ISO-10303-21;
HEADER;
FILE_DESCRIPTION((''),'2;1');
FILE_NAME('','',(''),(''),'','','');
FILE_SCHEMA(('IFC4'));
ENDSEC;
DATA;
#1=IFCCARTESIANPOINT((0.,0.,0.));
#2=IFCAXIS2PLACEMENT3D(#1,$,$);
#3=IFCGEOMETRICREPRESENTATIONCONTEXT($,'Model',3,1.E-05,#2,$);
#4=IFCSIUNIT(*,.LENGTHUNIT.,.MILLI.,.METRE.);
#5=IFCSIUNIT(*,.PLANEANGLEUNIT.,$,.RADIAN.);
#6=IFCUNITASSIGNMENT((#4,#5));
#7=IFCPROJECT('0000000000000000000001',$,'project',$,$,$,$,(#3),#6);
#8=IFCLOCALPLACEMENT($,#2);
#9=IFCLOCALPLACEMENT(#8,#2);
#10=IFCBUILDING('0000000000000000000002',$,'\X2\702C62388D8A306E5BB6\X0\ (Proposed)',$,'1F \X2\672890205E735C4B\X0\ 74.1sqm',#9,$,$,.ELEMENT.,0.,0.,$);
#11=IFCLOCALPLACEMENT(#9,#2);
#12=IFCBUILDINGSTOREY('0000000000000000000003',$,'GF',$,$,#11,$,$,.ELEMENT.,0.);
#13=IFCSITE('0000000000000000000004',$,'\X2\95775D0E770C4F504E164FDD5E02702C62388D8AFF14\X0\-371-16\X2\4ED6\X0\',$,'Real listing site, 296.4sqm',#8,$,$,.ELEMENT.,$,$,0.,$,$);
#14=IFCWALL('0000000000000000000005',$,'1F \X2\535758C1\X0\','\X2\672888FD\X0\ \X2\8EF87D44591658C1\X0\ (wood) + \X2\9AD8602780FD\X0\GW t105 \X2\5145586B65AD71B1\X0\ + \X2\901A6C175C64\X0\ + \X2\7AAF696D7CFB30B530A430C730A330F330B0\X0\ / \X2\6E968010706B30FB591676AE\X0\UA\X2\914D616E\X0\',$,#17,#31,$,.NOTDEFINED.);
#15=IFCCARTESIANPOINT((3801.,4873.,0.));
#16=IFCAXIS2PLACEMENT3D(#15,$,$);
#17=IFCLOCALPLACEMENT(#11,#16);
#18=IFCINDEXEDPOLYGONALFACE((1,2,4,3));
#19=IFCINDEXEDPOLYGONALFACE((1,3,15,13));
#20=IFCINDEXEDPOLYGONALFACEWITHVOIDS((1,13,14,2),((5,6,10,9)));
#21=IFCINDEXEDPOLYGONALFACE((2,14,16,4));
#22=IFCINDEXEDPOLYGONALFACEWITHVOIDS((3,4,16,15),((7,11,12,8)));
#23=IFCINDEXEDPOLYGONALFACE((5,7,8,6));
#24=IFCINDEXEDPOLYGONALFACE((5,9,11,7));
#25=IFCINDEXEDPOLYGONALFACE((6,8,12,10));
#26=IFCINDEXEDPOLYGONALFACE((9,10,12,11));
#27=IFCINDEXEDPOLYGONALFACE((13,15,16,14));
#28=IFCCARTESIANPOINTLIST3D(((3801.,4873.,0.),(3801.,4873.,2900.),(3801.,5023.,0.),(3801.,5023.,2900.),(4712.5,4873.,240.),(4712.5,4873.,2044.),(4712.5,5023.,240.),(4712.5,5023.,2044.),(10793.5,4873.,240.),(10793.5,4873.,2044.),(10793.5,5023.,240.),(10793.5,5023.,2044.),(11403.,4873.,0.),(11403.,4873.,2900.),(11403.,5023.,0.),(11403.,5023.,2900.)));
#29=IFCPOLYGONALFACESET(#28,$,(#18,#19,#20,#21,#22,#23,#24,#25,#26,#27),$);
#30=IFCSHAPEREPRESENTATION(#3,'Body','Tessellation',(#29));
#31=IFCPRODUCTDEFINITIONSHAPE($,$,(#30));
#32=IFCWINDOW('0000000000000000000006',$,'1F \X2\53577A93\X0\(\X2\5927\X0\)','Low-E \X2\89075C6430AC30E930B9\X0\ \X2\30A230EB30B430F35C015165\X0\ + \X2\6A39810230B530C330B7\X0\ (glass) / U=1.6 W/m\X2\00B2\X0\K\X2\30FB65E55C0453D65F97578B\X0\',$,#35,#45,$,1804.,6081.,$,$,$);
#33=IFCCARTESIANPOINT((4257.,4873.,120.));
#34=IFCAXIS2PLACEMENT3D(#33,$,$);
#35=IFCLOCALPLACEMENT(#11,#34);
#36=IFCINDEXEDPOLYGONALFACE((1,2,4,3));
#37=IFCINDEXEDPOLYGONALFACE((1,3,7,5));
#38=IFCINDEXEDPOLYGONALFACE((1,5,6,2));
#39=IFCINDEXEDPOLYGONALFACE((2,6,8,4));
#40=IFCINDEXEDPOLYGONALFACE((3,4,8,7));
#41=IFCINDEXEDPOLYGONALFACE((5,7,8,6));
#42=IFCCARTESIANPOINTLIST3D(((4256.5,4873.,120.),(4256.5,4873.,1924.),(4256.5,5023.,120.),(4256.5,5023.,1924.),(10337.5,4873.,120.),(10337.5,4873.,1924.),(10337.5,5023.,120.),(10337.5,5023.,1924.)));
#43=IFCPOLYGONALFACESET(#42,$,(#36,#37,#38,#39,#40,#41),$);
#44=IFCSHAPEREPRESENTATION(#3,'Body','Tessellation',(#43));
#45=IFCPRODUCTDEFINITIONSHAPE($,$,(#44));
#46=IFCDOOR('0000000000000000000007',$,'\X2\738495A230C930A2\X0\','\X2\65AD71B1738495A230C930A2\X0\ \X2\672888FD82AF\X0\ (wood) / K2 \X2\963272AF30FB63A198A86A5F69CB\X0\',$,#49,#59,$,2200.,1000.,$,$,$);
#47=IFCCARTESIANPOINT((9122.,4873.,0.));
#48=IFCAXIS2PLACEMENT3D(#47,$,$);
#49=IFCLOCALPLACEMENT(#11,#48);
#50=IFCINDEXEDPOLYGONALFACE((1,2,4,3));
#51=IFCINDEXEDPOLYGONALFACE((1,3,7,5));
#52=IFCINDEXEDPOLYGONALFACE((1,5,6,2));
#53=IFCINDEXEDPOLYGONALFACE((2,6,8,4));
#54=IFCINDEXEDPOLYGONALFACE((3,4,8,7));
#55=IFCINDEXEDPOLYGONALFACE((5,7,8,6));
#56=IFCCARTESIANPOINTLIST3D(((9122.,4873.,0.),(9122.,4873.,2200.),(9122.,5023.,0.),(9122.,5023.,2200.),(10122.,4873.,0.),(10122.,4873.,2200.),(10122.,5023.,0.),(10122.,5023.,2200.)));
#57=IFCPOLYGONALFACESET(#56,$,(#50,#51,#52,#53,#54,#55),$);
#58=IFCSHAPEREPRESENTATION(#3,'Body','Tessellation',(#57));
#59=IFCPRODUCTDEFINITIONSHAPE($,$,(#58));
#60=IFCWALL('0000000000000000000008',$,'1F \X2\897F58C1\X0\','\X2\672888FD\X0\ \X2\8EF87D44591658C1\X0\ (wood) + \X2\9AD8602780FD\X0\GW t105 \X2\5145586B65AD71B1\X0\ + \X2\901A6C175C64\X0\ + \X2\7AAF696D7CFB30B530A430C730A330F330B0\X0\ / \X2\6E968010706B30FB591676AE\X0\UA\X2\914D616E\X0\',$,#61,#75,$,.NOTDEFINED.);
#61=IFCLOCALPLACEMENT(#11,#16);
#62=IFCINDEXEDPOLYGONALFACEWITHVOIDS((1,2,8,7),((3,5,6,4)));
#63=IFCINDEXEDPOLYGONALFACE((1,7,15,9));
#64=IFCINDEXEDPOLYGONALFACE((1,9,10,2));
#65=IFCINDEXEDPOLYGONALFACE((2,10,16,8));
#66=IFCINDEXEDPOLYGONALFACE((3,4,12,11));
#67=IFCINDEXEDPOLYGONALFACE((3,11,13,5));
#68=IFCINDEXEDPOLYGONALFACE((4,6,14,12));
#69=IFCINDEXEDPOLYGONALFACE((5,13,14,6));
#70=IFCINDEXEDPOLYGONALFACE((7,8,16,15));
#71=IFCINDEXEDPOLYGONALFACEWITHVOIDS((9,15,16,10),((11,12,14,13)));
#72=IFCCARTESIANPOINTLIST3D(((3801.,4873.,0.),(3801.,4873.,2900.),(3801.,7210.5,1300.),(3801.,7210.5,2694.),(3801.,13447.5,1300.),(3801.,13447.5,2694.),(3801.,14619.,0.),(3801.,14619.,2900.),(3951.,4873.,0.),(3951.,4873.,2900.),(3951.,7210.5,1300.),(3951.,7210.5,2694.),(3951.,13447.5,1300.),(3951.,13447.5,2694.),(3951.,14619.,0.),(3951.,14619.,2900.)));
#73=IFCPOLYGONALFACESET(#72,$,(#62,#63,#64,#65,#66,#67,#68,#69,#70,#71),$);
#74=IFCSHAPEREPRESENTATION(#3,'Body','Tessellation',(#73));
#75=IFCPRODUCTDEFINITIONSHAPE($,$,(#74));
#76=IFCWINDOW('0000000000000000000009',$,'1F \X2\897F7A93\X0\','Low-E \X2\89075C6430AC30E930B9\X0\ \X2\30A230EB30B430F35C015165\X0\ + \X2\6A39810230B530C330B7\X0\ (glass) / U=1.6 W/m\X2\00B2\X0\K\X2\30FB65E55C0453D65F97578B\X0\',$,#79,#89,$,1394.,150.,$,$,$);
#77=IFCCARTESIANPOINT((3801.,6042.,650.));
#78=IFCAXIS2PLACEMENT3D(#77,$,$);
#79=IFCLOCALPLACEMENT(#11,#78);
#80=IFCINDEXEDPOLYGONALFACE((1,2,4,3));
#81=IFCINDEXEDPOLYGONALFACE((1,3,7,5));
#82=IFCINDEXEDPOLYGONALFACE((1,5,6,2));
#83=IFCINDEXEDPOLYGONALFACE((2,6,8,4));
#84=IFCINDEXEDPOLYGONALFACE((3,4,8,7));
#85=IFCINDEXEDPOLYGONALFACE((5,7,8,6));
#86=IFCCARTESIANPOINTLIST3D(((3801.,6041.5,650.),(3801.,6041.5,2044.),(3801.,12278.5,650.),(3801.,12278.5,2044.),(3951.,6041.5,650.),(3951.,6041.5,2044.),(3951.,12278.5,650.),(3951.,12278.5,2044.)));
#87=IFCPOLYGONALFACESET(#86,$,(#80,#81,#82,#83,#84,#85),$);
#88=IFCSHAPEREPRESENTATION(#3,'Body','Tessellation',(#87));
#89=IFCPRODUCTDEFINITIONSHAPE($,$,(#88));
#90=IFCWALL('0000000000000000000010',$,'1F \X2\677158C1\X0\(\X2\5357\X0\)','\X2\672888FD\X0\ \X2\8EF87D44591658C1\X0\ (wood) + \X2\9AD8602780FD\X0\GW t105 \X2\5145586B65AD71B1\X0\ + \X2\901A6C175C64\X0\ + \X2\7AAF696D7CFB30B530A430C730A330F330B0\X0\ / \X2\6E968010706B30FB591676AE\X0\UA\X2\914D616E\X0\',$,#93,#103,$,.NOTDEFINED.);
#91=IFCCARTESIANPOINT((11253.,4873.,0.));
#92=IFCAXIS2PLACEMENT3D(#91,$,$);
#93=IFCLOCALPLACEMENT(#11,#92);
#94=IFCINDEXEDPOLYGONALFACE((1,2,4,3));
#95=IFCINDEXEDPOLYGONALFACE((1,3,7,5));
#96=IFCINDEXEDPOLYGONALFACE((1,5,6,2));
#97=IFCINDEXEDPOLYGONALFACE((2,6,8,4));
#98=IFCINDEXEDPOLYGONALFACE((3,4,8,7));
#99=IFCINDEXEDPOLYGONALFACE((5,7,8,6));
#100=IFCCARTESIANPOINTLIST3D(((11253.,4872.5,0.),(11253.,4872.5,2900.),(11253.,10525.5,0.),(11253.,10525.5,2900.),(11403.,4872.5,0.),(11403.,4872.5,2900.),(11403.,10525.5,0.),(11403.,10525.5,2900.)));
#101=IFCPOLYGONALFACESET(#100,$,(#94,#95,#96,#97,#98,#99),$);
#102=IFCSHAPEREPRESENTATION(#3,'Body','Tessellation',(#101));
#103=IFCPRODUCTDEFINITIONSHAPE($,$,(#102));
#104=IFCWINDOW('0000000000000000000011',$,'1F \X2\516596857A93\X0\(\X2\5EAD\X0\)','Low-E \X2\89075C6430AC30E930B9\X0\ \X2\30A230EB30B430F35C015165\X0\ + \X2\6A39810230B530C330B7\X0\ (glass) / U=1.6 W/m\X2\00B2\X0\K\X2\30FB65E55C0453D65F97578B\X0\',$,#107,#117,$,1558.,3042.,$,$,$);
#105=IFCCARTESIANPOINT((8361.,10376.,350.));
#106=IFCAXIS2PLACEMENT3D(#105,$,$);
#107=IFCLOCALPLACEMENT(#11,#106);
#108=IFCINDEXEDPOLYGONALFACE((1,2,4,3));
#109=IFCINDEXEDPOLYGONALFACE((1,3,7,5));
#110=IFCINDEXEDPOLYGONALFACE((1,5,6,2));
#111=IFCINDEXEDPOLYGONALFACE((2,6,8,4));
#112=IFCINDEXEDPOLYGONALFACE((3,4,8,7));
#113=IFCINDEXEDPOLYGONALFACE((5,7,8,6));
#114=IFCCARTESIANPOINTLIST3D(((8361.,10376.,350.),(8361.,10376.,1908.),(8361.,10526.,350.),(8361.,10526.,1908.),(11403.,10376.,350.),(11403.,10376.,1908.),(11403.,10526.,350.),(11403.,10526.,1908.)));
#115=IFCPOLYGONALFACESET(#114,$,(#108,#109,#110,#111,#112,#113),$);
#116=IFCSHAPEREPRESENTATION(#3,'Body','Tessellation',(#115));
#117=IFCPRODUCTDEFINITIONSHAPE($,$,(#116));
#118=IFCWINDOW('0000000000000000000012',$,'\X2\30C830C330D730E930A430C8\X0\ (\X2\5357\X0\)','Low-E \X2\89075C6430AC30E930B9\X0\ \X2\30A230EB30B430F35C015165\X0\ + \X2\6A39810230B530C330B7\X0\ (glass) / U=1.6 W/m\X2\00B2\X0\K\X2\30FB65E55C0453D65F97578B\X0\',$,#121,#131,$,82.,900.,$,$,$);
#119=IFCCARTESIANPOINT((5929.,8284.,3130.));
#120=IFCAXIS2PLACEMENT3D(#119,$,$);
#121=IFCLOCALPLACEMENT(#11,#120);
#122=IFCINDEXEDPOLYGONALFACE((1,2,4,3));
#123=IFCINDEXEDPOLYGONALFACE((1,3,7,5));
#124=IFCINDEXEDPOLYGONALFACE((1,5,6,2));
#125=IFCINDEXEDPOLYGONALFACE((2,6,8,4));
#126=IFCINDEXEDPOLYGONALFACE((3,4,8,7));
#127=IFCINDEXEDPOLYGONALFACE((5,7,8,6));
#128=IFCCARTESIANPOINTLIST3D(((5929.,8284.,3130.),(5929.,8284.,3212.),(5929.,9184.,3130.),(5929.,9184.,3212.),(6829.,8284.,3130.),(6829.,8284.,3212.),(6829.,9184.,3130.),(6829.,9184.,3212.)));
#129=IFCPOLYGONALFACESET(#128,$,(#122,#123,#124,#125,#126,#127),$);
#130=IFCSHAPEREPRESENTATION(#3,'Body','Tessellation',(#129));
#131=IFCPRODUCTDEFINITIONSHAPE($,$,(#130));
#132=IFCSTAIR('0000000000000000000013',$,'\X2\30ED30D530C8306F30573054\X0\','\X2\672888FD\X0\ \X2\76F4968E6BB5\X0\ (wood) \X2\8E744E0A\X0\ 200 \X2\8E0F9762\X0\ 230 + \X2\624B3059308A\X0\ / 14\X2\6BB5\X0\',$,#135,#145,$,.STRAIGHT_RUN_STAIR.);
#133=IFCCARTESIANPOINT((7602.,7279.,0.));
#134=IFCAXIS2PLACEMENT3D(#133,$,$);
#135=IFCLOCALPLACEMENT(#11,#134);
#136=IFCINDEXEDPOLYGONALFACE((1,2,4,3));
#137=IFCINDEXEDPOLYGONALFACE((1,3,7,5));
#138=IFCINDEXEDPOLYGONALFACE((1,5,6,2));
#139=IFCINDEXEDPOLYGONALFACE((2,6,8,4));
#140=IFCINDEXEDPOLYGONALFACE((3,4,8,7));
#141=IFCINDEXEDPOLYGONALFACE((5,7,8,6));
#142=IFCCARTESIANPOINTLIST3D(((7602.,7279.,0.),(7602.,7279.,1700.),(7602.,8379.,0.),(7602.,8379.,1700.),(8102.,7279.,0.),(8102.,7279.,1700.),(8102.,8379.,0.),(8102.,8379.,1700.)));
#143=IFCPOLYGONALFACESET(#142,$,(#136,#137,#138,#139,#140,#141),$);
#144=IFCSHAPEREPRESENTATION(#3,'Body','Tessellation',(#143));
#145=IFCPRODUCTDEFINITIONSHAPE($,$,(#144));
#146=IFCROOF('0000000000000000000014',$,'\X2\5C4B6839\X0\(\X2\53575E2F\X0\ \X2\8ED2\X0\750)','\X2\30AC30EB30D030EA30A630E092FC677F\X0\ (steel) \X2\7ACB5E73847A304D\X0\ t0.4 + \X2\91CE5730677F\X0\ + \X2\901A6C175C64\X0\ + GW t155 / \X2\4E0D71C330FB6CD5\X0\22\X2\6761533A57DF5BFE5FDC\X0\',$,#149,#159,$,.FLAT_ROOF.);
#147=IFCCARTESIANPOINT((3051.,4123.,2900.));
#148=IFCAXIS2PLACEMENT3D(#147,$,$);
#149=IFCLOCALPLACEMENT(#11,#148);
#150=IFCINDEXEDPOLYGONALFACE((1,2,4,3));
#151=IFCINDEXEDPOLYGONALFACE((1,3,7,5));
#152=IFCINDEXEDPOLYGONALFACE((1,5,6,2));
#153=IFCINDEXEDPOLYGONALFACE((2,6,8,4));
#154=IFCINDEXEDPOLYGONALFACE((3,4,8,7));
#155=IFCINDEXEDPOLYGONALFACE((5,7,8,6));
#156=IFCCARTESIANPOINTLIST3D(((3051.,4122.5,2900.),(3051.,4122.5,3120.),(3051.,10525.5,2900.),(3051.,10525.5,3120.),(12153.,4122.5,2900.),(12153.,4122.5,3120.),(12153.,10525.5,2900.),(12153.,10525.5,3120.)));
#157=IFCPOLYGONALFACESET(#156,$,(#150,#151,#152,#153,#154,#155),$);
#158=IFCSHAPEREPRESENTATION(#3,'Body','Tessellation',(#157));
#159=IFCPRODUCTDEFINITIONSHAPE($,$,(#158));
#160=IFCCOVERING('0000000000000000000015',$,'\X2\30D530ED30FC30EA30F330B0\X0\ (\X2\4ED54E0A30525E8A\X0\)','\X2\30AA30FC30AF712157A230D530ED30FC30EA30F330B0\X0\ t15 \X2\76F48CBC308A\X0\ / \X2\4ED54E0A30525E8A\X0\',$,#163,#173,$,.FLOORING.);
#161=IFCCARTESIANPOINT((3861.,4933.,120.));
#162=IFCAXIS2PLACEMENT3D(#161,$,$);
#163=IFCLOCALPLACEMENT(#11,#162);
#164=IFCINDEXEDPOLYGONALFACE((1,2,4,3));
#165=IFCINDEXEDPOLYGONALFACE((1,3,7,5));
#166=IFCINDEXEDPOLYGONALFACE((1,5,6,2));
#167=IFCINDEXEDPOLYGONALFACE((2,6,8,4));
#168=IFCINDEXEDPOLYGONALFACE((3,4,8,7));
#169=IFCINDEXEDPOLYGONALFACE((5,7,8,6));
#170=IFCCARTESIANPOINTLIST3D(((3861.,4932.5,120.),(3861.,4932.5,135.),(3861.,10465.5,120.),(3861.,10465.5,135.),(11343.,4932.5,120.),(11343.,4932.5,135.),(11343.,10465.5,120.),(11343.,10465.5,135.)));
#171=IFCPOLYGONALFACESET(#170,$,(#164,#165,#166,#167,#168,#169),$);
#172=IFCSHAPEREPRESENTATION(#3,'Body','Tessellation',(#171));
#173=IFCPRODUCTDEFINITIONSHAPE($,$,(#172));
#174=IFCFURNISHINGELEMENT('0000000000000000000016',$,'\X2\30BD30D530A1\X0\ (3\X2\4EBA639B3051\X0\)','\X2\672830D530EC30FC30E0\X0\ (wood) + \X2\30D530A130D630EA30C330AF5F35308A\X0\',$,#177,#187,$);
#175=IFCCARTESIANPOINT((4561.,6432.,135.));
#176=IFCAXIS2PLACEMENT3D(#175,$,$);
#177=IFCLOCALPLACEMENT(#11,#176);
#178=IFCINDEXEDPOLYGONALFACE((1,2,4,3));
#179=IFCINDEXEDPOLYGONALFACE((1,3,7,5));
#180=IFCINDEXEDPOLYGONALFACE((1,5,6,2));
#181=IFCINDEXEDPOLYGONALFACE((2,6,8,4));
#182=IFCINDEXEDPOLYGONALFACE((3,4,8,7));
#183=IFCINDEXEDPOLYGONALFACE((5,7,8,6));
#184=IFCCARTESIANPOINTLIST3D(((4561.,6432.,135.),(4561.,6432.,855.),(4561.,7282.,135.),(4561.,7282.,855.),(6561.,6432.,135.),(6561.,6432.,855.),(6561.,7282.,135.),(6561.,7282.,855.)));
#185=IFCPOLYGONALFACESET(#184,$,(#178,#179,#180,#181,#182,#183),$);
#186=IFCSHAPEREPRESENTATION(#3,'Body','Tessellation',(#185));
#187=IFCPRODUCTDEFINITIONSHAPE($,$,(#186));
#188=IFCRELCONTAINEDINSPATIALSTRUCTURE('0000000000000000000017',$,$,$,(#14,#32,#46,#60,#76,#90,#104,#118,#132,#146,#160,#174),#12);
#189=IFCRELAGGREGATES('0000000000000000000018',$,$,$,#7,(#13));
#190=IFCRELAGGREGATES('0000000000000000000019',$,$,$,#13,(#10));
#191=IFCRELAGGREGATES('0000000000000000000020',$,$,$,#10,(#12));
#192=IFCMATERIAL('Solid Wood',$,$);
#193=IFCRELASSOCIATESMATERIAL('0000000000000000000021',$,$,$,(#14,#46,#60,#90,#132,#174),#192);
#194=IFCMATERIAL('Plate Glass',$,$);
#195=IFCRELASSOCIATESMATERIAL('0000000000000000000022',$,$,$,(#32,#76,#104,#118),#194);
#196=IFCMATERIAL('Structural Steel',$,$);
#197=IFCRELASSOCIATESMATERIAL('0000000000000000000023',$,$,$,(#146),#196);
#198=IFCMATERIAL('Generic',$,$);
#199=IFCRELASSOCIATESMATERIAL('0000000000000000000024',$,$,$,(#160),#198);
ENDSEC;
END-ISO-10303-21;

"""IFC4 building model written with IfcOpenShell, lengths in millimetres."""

from ifc_helpers import new_model, si_unit, frame, frame_2d, origin, place, context, project, spatial, rectangle, extrude, material, element, fill, save


model = new_model("IFC4")

# Units and contexts
model_context = context("Model", 3, precision=1e-05, world=origin())
ifc_project = project(units=[si_unit("LENGTHUNIT", "METRE", prefix="MILLI"), si_unit("PLANEANGLEUNIT", "RADIAN")], contexts=[model_context])

# Site, building, storey
site_placement = place(None, origin())
site = spatial("IfcSite", under=ifc_project, at=site_placement, Name="長崎県佐世保市瀬戸越４-371-16他", ObjectType="Real listing site, 296.4sqm", CompositionType="ELEMENT", RefElevation=0.0)
building_placement = place(site_placement, origin())
building = spatial("IfcBuilding", under=site, at=building_placement, Name="瀬戸越の家 (Proposed)", ObjectType="1F 木造平屋 74.1sqm", CompositionType="ELEMENT", ElevationOfRefHeight=0.0, ElevationOfTerrain=0.0)
storey_placement = place(building_placement, origin())
storey = spatial("IfcBuildingStorey", under=building, at=storey_placement, Name="GF", CompositionType="ELEMENT", Elevation=0.0)

# Shared definitions
ifc_material_1 = material(Name="Solid Wood")

# Wall, openings, window, door
wall_1_placement = place(storey_placement, frame((3801.0, 4873.0, 0.0)))
wall_1 = element("IfcWall", 1, at=wall_1_placement, inside=storey, material=ifc_material_1, Name="1F 南壁", Description="木製 軸組外壁 (wood) + 高性能GW t105 充填断熱 + 通気層 + 窯業系サイディング / 準耐火・外皮UA配慮", PredefinedType="NOTDEFINED", context=model_context, shape_type="SweptSolid", body=[
    extrude(rectangle(XDim=7602.0, YDim=150.0, at=frame_2d((3801.0, 75.0))), frame((3801.0, 4873.0, 0.0)), (0.0, 0.0, 1.0), 2900.0),
])
opening_1_placement = place(storey_placement, frame((4257.0, 4873.0, 120.0)))
opening_1 = element("IfcOpeningElement", 2, at=opening_1_placement, cuts=wall_1, PredefinedType="NOTDEFINED", context=model_context, shape_type="SweptSolid", body=[
    extrude(rectangle(XDim=6081.0, YDim=150.0, at=frame_2d((3040.0, 75.0))), frame((4257.0, 4873.0, 120.0)), (0.0, 0.0, 1.0), 1804.0),
])
opening_2_placement = place(storey_placement, frame((9122.0, 4873.0, 0.0)))
opening_2 = element("IfcOpeningElement", 3, at=opening_2_placement, cuts=wall_1, PredefinedType="NOTDEFINED", context=model_context, shape_type="SweptSolid", body=[
    extrude(rectangle(XDim=1000.0, YDim=150.0, at=frame_2d((500.0, 75.0))), frame((9122.0, 4873.0, 0.0)), (0.0, 0.0, 1.0), 2200.0),
])
ifc_material_2 = material(Name="Plate Glass")
window_1_placement = place(storey_placement, frame((4257.0, 4873.0, 120.0)))
window_1 = element("IfcWindow", 4, at=window_1_placement, inside=storey, material=ifc_material_2, Name="1F 南窓(大)", Description="Low-E 複層ガラス アルゴン封入 + 樹脂サッシ (glass) / U=1.6 W/m²K・日射取得型", OverallHeight=1804.0, OverallWidth=6081.0, context=model_context, shape_type="SweptSolid", body=[
    extrude(rectangle(XDim=6081.0, YDim=150.0, at=frame_2d((3040.0, 75.0))), frame((4257.0, 4873.0, 120.0)), (0.0, 0.0, 1.0), 1804.0),
])
fill(opening_1, window_1)
door_1_placement = place(storey_placement, frame((9122.0, 4873.0, 0.0)))
door_1 = element("IfcDoor", 5, at=door_1_placement, inside=storey, material=ifc_material_1, Name="玄関ドア", Description="断熱玄関ドア 木製芯 (wood) / K2 防犯・採風機構", OverallHeight=2200.0, OverallWidth=1000.0, context=model_context, shape_type="SweptSolid", body=[
    extrude(rectangle(XDim=1000.0, YDim=150.0, at=frame_2d((500.0, 75.0))), frame((9122.0, 4873.0, 0.0)), (0.0, 0.0, 1.0), 2200.0),
])
fill(opening_2, door_1)

# Walls, openings, windows
wall_2_placement = place(storey_placement, frame((3801.0, 4873.0, 0.0)))
wall_2 = element("IfcWall", 6, at=wall_2_placement, inside=storey, material=ifc_material_1, Name="1F 西壁", Description="木製 軸組外壁 (wood) + 高性能GW t105 充填断熱 + 通気層 + 窯業系サイディング / 準耐火・外皮UA配慮", PredefinedType="NOTDEFINED", context=model_context, shape_type="SweptSolid", body=[
    extrude(rectangle(XDim=150.0, YDim=9746.0, at=frame_2d((75.0, 4873.0))), frame((3801.0, 4873.0, 0.0)), (0.0, 0.0, 1.0), 2900.0),
])
opening_3_placement = place(storey_placement, frame((3801.0, 6042.0, 650.0)))
opening_3 = element("IfcOpeningElement", 7, at=opening_3_placement, cuts=wall_2, PredefinedType="NOTDEFINED", context=model_context, shape_type="SweptSolid", body=[
    extrude(rectangle(XDim=150.0, YDim=6237.0, at=frame_2d((75.0, 3118.0))), frame((3801.0, 6042.0, 650.0)), (0.0, 0.0, 1.0), 1394.0),
])
window_2_placement = place(storey_placement, frame((3801.0, 6042.0, 650.0)))
window_2 = element("IfcWindow", 8, at=window_2_placement, inside=storey, material=ifc_material_2, Name="1F 西窓", Description="Low-E 複層ガラス アルゴン封入 + 樹脂サッシ (glass) / U=1.6 W/m²K・日射取得型", OverallHeight=1394.0, OverallWidth=150.0, context=model_context, shape_type="SweptSolid", body=[
    extrude(rectangle(XDim=150.0, YDim=6237.0, at=frame_2d((75.0, 3118.0))), frame((3801.0, 6042.0, 650.0)), (0.0, 0.0, 1.0), 1394.0),
])
fill(opening_3, window_2)
wall_3_placement = place(storey_placement, frame((11253.0, 4873.0, 0.0)))
wall_3 = element("IfcWall", 9, at=wall_3_placement, inside=storey, material=ifc_material_1, Name="1F 東壁(南)", Description="木製 軸組外壁 (wood) + 高性能GW t105 充填断熱 + 通気層 + 窯業系サイディング / 準耐火・外皮UA配慮", PredefinedType="NOTDEFINED", context=model_context, shape_type="SweptSolid", body=[
    extrude(rectangle(XDim=150.0, YDim=5653.0, at=frame_2d((75.0, 2826.0))), frame((11253.0, 4873.0, 0.0)), (0.0, 0.0, 1.0), 2900.0),
])
opening_4_placement = place(storey_placement, frame((8361.0, 10376.0, 350.0)))
opening_4 = element("IfcOpeningElement", 10, at=opening_4_placement, cuts=wall_3, PredefinedType="NOTDEFINED", context=model_context, shape_type="SweptSolid", body=[
    extrude(rectangle(XDim=3042.0, YDim=150.0, at=frame_2d((1521.0, 75.0))), frame((8361.0, 10376.0, 350.0)), (0.0, 0.0, 1.0), 1558.0),
])
window_3_placement = place(storey_placement, frame((8361.0, 10376.0, 350.0)))
window_3 = element("IfcWindow", 11, at=window_3_placement, inside=storey, material=ifc_material_2, Name="1F 入隅窓(庭)", Description="Low-E 複層ガラス アルゴン封入 + 樹脂サッシ (glass) / U=1.6 W/m²K・日射取得型", OverallHeight=1558.0, OverallWidth=3042.0, context=model_context, shape_type="SweptSolid", body=[
    extrude(rectangle(XDim=3042.0, YDim=150.0, at=frame_2d((1521.0, 75.0))), frame((8361.0, 10376.0, 350.0)), (0.0, 0.0, 1.0), 1558.0),
])
fill(opening_4, window_3)

# Window
window_4_placement = place(storey_placement, frame((5929.0, 8284.0, 3130.0)))
element("IfcWindow", 12, at=window_4_placement, inside=storey, material=ifc_material_2, Name="トップライト (南)", Description="Low-E 複層ガラス アルゴン封入 + 樹脂サッシ (glass) / U=1.6 W/m²K・日射取得型", OverallHeight=82.0, OverallWidth=900.0, context=model_context, shape_type="SweptSolid", body=[
    extrude(rectangle(XDim=900.0, YDim=900.0, at=frame_2d((450.0, 450.0))), frame((5929.0, 8284.0, 3130.0)), (0.0, 0.0, 1.0), 82.0),
])

# Stair
stair_placement = place(storey_placement, frame((7602.0, 7279.0, 0.0)))
element("IfcStair", 13, at=stair_placement, inside=storey, material=ifc_material_1, Name="ロフトはしご", Description="木製 直階段 (wood) 蹴上 200 踏面 230 + 手すり / 14段", PredefinedType="STRAIGHT_RUN_STAIR", context=model_context, shape_type="SweptSolid", body=[
    extrude(rectangle(XDim=500.0, YDim=1100.0, at=frame_2d((250.0, 550.0))), frame((7602.0, 7279.0, 0.0)), (0.0, 0.0, 1.0), 1700.0),
])

# Roof
ifc_material_3 = material(Name="Structural Steel")
roof_placement = place(storey_placement, frame((3051.0, 4123.0, 2900.0)))
element("IfcRoof", 14, at=roof_placement, inside=storey, material=ifc_material_3, Name="屋根(南帯 軒750)", Description="ガルバリウム鋼板 (steel) 立平葺き t0.4 + 野地板 + 通気層 + GW t155 / 不燃・法22条区域対応", PredefinedType="FLAT_ROOF", context=model_context, shape_type="SweptSolid", body=[
    extrude(rectangle(XDim=9102.0, YDim=6403.0, at=frame_2d((4551.0, 3201.0))), frame((3051.0, 4123.0, 2900.0)), (0.0, 0.0, 1.0), 220.0),
])

# Covering
ifc_material_4 = material(Name="Generic")
covering_placement = place(storey_placement, frame((3861.0, 4933.0, 120.0)))
element("IfcCovering", 15, at=covering_placement, inside=storey, material=ifc_material_4, Name="フローリング (仕上げ床)", Description="オーク無垢フローリング t15 直貼り / 仕上げ床", PredefinedType="FLOORING", context=model_context, shape_type="SweptSolid", body=[
    extrude(rectangle(XDim=7482.0, YDim=5533.0, at=frame_2d((3741.0, 2766.0))), frame((3861.0, 4933.0, 120.0)), (0.0, 0.0, 1.0), 15.0),
])

# Furnishing element
furnishing_1_placement = place(storey_placement, frame((4561.0, 6432.0, 135.0)))
element("IfcFurnishingElement", 16, at=furnishing_1_placement, inside=storey, material=ifc_material_1, Name="ソファ (3人掛け)", Description="木フレーム (wood) + ファブリック張り", context=model_context, shape_type="SweptSolid", body=[
    extrude(rectangle(XDim=2000.0, YDim=850.0, at=frame_2d((1000.0, 425.0))), frame((4561.0, 6432.0, 135.0)), (0.0, 0.0, 1.0), 720.0),
])

save(model, "model.ifc")
